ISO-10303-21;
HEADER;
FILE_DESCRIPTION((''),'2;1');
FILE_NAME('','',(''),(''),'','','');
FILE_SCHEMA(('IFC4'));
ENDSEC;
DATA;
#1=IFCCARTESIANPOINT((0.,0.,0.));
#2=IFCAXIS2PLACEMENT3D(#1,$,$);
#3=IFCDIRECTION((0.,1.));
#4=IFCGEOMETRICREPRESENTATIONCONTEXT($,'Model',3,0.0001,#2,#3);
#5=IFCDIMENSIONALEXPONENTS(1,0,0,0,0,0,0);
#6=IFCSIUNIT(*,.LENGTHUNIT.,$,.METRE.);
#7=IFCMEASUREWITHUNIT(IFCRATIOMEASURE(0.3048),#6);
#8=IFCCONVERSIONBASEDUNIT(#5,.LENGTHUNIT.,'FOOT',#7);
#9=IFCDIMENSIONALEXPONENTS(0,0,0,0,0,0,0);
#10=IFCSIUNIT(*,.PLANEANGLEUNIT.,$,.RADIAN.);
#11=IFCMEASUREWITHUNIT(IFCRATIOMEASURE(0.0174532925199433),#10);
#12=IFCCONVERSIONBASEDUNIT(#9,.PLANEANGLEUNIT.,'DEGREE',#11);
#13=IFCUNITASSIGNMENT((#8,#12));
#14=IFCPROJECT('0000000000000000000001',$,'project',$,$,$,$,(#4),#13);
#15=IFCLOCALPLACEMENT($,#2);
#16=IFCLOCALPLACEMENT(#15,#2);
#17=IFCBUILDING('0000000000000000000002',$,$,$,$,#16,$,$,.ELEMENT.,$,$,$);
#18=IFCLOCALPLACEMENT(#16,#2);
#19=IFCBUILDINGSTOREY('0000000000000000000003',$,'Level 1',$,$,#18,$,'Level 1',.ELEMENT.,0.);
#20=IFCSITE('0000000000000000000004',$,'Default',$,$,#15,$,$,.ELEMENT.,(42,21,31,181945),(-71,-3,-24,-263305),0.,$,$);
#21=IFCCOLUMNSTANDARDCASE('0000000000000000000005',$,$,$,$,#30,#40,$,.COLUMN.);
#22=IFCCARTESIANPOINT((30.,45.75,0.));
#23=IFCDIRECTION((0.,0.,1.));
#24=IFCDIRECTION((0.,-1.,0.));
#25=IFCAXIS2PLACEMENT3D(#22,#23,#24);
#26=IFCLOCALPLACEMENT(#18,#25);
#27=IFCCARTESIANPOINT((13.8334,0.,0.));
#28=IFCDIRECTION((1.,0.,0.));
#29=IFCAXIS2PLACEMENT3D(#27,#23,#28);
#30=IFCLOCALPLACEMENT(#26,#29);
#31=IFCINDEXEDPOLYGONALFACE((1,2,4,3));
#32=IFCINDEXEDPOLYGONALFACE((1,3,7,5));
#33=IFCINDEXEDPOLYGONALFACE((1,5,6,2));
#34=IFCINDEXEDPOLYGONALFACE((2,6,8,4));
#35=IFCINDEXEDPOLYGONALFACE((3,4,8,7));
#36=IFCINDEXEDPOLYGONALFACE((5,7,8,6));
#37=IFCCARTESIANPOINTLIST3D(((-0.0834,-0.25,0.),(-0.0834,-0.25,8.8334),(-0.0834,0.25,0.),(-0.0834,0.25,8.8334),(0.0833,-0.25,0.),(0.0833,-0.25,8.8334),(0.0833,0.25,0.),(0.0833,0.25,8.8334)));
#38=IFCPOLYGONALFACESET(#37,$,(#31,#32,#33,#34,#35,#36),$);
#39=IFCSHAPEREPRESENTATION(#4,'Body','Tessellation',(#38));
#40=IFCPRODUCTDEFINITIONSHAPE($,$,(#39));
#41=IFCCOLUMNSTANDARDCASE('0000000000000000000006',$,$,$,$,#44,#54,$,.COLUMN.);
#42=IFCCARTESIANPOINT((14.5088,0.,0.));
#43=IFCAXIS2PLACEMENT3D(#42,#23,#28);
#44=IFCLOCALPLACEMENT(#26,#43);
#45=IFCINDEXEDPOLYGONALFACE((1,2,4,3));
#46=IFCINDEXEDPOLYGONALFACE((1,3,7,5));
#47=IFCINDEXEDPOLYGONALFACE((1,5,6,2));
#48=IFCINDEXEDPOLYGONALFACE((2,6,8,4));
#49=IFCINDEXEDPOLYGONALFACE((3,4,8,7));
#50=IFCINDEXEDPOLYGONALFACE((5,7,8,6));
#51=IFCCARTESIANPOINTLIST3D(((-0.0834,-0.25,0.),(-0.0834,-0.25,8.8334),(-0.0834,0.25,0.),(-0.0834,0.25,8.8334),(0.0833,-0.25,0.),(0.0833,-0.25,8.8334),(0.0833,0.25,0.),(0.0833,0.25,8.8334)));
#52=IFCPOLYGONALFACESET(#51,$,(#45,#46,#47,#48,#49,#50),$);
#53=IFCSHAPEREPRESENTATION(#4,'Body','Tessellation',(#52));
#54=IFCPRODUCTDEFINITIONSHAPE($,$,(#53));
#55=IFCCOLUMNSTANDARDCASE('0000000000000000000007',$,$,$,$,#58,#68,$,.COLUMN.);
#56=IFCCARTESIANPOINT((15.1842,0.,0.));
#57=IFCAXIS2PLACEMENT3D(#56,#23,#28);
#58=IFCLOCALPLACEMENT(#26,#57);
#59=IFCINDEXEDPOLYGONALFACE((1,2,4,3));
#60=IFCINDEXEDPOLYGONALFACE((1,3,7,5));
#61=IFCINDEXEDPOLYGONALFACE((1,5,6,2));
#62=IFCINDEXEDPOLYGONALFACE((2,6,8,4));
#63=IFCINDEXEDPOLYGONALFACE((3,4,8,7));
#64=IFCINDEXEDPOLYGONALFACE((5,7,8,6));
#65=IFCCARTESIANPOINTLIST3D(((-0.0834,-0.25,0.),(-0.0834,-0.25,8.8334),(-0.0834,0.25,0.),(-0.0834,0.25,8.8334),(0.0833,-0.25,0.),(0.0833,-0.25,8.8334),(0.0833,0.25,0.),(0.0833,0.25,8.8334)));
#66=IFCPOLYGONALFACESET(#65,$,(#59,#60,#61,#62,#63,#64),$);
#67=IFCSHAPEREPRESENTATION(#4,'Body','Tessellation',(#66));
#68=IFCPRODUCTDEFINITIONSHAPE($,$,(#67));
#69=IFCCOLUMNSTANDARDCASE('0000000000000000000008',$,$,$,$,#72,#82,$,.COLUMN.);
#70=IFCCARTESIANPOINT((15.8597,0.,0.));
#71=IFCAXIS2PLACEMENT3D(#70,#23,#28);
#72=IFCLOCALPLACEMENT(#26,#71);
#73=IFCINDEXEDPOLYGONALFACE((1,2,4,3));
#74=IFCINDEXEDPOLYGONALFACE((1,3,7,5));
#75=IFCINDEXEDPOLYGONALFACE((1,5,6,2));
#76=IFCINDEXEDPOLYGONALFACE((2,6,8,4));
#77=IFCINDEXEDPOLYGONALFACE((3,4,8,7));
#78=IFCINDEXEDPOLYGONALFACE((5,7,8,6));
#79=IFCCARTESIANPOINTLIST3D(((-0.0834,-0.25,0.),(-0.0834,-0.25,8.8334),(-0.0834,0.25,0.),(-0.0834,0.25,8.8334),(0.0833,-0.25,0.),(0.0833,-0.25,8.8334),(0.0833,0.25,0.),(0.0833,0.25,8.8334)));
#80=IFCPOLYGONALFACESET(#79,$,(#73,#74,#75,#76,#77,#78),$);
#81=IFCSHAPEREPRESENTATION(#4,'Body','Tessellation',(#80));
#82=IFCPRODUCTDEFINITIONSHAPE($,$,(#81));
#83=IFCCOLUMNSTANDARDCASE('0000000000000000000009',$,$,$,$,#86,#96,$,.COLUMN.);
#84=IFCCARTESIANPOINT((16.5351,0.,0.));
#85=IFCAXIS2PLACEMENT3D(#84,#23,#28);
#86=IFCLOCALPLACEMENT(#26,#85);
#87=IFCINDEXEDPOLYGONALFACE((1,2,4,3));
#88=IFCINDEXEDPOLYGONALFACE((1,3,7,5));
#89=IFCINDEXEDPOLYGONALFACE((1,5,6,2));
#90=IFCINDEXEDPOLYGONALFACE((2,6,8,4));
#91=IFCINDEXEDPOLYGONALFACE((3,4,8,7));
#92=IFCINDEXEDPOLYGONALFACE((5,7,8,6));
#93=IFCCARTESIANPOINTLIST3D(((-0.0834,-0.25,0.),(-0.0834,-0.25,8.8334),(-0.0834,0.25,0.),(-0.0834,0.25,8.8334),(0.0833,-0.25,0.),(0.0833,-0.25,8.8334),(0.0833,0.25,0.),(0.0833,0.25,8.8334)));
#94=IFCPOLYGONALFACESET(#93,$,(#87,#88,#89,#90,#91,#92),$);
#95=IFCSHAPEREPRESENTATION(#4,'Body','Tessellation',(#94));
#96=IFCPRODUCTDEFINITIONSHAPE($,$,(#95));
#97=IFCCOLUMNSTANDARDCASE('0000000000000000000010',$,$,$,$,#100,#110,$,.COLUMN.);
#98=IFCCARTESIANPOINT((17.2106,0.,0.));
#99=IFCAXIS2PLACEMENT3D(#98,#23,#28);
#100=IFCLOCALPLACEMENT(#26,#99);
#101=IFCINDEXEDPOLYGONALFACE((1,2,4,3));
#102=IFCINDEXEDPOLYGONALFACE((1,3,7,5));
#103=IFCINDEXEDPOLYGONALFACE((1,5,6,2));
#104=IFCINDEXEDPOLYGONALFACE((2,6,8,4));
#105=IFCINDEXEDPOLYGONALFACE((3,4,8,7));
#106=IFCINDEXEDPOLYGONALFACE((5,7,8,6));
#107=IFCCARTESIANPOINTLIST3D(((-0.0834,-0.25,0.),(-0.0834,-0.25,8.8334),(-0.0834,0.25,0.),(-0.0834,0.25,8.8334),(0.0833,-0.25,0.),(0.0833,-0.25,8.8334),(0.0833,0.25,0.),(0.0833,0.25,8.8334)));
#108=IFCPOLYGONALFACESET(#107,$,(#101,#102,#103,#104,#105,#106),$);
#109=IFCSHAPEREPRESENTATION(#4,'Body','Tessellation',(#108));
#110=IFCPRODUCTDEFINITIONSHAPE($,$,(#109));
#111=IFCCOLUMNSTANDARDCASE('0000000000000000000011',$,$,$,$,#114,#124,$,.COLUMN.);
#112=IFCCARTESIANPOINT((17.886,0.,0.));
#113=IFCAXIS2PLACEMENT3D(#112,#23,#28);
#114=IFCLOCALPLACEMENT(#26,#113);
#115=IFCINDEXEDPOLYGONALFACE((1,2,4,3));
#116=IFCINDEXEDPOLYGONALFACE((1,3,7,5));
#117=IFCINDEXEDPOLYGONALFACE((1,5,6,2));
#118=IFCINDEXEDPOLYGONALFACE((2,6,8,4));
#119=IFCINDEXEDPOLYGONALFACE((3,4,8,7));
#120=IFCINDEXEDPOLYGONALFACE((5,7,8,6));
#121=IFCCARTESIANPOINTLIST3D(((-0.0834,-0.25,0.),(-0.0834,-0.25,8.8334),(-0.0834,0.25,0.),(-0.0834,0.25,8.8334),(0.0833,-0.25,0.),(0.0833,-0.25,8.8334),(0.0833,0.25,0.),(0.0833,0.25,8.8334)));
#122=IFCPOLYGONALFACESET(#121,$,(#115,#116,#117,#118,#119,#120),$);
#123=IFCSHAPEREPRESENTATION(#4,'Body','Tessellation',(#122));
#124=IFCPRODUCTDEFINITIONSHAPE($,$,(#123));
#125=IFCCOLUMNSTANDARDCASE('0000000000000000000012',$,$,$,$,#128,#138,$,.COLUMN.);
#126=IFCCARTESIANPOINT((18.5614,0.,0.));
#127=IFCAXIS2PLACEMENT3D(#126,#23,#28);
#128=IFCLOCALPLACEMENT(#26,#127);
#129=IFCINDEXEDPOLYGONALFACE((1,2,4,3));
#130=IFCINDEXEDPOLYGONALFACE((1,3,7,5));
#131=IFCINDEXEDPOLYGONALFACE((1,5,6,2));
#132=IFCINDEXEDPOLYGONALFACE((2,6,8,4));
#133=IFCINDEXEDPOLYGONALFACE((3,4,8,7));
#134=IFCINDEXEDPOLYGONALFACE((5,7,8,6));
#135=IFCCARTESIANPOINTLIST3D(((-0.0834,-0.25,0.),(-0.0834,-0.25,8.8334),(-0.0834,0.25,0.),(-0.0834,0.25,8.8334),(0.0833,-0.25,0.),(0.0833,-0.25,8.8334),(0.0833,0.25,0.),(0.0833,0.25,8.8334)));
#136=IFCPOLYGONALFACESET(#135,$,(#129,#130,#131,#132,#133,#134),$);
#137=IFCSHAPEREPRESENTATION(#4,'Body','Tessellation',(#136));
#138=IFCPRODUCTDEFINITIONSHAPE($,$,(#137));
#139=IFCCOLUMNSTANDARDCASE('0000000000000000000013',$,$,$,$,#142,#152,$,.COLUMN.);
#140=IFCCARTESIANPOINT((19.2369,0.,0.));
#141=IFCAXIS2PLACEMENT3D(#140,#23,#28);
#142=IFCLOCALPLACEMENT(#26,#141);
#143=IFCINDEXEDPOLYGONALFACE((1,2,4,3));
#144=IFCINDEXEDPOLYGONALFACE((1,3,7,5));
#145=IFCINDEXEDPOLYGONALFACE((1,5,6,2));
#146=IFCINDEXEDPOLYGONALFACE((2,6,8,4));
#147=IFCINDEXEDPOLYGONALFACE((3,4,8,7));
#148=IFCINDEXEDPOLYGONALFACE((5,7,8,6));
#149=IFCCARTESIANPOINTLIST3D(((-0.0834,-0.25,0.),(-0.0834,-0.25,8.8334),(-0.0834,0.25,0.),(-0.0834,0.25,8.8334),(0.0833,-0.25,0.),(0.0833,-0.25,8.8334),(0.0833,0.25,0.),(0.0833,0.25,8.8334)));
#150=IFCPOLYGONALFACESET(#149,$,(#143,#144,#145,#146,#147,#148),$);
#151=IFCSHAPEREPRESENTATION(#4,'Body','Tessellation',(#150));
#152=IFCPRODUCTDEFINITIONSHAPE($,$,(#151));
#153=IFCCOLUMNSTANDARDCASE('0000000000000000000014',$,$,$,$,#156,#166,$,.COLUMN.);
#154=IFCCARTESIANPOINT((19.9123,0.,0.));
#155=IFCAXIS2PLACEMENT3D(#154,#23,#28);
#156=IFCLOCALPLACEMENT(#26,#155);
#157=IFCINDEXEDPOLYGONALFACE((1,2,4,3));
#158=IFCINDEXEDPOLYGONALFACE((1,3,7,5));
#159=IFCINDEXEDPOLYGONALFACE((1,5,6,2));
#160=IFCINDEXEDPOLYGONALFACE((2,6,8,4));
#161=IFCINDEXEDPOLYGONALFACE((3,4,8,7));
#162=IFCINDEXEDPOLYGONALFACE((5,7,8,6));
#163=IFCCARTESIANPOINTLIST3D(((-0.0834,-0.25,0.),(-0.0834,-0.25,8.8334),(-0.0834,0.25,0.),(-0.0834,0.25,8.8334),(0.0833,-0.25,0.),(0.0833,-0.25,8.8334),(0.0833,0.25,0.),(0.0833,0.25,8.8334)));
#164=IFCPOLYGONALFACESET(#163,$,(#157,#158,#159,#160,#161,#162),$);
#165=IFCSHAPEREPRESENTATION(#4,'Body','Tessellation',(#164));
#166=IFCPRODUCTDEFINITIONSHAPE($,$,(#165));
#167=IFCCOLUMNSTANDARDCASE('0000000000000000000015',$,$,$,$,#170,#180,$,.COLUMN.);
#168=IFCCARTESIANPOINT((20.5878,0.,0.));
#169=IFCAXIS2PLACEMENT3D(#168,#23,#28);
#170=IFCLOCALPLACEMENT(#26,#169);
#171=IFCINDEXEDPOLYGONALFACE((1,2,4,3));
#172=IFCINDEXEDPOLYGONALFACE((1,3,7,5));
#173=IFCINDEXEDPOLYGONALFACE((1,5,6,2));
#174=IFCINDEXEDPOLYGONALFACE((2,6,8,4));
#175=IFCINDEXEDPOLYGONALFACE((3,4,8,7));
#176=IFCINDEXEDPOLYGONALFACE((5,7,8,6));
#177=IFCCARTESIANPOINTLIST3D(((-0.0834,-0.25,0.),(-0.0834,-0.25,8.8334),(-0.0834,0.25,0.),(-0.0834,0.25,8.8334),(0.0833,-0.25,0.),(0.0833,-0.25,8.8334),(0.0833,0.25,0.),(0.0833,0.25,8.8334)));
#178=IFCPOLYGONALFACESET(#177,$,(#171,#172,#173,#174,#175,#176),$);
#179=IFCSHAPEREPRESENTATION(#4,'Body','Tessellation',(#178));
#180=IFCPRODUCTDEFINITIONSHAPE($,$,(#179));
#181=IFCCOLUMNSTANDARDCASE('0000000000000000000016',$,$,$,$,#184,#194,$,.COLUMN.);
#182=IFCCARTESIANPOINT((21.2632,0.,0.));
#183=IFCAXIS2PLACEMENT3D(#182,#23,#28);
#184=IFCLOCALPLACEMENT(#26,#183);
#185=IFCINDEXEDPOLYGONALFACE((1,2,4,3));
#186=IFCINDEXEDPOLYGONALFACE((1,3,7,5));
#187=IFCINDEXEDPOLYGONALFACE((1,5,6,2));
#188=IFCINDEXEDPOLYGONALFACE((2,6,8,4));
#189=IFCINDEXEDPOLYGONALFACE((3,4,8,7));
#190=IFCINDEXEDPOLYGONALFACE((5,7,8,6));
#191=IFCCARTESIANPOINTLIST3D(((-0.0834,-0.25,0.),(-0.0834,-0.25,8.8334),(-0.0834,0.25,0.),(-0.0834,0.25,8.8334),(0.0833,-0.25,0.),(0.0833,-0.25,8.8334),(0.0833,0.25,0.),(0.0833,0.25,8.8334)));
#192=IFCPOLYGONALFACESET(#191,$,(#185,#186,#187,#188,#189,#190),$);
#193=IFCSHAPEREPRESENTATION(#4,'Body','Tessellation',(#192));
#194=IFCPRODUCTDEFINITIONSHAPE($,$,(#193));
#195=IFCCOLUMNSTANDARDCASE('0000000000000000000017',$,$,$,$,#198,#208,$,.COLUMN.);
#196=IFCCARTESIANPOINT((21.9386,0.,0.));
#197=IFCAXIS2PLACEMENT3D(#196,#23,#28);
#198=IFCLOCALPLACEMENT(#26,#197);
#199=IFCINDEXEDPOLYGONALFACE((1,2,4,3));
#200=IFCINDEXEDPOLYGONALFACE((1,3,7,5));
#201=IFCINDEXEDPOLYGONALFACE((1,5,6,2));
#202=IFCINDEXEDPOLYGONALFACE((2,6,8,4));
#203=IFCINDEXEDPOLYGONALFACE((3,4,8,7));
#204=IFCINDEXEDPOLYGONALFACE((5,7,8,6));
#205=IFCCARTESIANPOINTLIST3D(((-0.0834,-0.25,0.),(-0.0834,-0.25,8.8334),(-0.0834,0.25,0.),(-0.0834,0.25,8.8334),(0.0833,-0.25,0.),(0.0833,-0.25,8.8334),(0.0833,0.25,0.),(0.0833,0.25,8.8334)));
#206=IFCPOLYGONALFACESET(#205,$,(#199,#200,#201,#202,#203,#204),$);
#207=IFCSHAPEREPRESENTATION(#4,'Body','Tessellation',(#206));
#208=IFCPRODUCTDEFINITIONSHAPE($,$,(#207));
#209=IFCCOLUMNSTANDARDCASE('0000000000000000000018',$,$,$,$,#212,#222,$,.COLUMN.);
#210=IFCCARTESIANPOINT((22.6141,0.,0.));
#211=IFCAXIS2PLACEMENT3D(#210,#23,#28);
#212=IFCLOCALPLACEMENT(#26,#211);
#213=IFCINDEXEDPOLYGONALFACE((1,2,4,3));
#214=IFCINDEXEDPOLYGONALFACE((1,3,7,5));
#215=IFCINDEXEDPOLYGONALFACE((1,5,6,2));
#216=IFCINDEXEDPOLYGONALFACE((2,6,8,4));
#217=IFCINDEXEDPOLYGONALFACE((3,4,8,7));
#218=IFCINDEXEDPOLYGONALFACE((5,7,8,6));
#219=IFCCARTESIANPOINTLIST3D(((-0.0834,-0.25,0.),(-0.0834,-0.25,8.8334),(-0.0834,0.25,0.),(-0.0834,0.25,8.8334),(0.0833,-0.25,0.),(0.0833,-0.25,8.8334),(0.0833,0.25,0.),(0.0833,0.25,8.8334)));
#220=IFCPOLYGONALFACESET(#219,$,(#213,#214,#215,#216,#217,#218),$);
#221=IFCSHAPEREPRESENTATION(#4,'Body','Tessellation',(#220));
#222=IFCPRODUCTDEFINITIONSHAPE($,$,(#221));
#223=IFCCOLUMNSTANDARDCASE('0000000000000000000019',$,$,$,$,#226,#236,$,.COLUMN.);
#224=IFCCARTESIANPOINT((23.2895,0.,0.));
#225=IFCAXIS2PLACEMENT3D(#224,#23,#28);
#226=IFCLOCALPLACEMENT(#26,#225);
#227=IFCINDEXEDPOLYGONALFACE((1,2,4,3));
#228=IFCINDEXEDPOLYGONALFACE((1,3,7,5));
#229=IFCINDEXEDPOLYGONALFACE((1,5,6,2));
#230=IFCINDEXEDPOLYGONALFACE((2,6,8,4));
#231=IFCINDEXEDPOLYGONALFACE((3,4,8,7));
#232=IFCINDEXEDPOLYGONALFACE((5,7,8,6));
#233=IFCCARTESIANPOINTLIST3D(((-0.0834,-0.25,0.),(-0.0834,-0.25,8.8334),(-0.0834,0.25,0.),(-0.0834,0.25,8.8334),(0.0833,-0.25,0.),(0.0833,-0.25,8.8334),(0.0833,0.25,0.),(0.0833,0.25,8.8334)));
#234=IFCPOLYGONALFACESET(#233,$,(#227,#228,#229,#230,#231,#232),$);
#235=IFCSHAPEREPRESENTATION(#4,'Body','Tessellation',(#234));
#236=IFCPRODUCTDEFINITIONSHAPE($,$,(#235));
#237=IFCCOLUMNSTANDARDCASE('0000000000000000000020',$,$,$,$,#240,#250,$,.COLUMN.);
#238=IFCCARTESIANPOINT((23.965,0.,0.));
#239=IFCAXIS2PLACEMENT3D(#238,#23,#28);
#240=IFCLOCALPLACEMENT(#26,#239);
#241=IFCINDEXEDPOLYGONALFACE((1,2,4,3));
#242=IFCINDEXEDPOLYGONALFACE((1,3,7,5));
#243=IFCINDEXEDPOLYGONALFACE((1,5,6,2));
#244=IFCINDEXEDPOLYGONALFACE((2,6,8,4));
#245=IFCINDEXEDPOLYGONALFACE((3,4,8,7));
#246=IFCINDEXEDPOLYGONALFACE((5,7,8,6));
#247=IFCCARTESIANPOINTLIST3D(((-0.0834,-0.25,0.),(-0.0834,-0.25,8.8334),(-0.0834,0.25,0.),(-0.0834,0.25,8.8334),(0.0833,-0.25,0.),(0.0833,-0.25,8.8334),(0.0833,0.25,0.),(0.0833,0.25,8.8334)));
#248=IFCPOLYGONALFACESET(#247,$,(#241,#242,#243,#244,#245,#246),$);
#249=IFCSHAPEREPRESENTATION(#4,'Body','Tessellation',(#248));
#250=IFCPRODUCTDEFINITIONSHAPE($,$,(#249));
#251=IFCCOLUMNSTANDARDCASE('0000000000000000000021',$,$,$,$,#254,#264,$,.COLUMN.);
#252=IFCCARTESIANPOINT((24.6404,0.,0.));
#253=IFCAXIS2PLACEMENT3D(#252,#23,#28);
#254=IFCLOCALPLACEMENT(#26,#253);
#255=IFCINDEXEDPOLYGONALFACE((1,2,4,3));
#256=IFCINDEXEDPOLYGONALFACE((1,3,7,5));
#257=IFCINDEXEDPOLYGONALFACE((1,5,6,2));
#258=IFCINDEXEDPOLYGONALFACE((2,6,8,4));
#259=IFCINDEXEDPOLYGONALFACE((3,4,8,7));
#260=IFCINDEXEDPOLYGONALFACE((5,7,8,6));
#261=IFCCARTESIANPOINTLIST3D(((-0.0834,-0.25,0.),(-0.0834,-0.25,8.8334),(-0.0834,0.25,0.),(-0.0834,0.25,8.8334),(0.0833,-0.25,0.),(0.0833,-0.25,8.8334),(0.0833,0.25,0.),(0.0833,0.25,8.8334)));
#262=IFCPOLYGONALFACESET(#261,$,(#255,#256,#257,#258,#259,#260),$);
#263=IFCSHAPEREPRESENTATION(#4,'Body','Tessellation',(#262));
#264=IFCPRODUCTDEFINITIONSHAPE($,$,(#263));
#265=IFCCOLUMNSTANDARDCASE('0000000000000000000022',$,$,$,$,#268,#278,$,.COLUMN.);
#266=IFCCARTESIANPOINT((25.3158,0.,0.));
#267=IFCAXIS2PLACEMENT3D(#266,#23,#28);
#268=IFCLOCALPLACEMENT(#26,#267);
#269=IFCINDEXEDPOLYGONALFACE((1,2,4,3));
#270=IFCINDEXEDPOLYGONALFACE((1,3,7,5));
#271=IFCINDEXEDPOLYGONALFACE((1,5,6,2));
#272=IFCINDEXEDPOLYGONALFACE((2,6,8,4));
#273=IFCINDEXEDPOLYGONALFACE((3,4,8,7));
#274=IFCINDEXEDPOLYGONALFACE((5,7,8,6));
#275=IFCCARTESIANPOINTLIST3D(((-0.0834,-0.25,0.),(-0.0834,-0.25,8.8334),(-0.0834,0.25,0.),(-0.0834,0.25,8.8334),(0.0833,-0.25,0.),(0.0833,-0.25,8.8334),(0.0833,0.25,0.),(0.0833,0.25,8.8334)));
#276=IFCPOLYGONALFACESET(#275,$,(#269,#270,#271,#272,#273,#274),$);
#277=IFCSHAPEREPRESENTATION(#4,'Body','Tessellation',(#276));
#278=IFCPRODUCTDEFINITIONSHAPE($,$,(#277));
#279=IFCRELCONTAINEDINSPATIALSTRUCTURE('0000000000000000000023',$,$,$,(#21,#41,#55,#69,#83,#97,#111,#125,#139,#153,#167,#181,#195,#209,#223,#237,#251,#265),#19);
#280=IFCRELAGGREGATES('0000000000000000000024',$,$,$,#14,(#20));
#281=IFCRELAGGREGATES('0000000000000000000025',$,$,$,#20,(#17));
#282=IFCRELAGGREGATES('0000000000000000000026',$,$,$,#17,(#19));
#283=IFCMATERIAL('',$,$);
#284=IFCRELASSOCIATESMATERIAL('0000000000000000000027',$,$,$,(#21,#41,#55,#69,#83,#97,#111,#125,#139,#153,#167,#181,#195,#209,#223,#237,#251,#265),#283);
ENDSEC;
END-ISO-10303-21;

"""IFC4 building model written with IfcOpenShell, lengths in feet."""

from ifc_helpers import new_model, entity, si_unit, converted_unit, direction, frame, origin, place, context, project, spatial, rectangle, extrude, material, element, save


model = new_model("IFC4")

# Units and contexts
model_context = context("Model", 3, precision=0.0001, world=origin(), true_north=direction((0.0, 1.0)))
ifc_project = project(units=[converted_unit("LENGTHUNIT", "FOOT", entity("IfcRatioMeasure", 0.3048), si_unit("LENGTHUNIT", "METRE"), dimensions=[1, 0, 0, 0, 0, 0, 0]), converted_unit("PLANEANGLEUNIT", "DEGREE", entity("IfcRatioMeasure", 0.0174532925199433), si_unit("PLANEANGLEUNIT", "RADIAN"), dimensions=[0, 0, 0, 0, 0, 0, 0])], contexts=[model_context])

# Site, building, storey
site_placement = place(None, origin())
site = spatial("IfcSite", under=ifc_project, at=site_placement, Name="Default", CompositionType="ELEMENT", RefLatitude=(42, 21, 31, 181945), RefLongitude=(-71, -3, -24, -263305), RefElevation=0.0)
building_placement = place(site_placement, origin())
building = spatial("IfcBuilding", under=site, at=building_placement, CompositionType="ELEMENT")
storey_placement = place(building_placement, origin())
storey = spatial("IfcBuildingStorey", under=building, at=storey_placement, Name="Level 1", LongName="Level 1", CompositionType="ELEMENT", Elevation=0.0)

# Columns
ifc_material_1 = material(Name="")
placement_1 = place(storey_placement, frame((30.0, 45.75, 0.0), z_axis=(0.0, 0.0, 1.0), x_axis=(0.0, -1.0, 0.0)))
for number, where, z_axis, x_axis in (
    (1, (13.8334, 0.0, 0.0), (0.0, 0.0, 1.0), (1.0, 0.0, 0.0)),
    (2, (14.5088, 0.0, 0.0), (0.0, 0.0, 1.0), (1.0, 0.0, 0.0)),
    (3, (15.1842, 0.0, 0.0), (0.0, 0.0, 1.0), (1.0, 0.0, 0.0)),
    (4, (15.8597, 0.0, 0.0), (0.0, 0.0, 1.0), (1.0, 0.0, 0.0)),
    (5, (16.5351, 0.0, 0.0), (0.0, 0.0, 1.0), (1.0, 0.0, 0.0)),
    (6, (17.2106, 0.0, 0.0), (0.0, 0.0, 1.0), (1.0, 0.0, 0.0)),
    (7, (17.886, 0.0, 0.0), (0.0, 0.0, 1.0), (1.0, 0.0, 0.0)),
    (8, (18.5614, 0.0, 0.0), (0.0, 0.0, 1.0), (1.0, 0.0, 0.0)),
    (9, (19.2369, 0.0, 0.0), (0.0, 0.0, 1.0), (1.0, 0.0, 0.0)),
    (10, (19.9123, 0.0, 0.0), (0.0, 0.0, 1.0), (1.0, 0.0, 0.0)),
    (11, (20.5878, 0.0, 0.0), (0.0, 0.0, 1.0), (1.0, 0.0, 0.0)),
    (12, (21.2632, 0.0, 0.0), (0.0, 0.0, 1.0), (1.0, 0.0, 0.0)),
    (13, (21.9386, 0.0, 0.0), (0.0, 0.0, 1.0), (1.0, 0.0, 0.0)),
    (14, (22.6141, 0.0, 0.0), (0.0, 0.0, 1.0), (1.0, 0.0, 0.0)),
    (15, (23.2895, 0.0, 0.0), (0.0, 0.0, 1.0), (1.0, 0.0, 0.0)),
    (16, (23.965, 0.0, 0.0), (0.0, 0.0, 1.0), (1.0, 0.0, 0.0)),
    (17, (24.6404, 0.0, 0.0), (0.0, 0.0, 1.0), (1.0, 0.0, 0.0)),
    (18, (25.3158, 0.0, 0.0), (0.0, 0.0, 1.0), (1.0, 0.0, 0.0)),
):
    element("IfcColumnStandardCase", number, at=place(placement_1, frame(where, z_axis=z_axis, x_axis=x_axis)), inside=storey, material=ifc_material_1, PredefinedType="COLUMN", context=model_context, shape_type="SweptSolid", body=[
        extrude(rectangle(XDim=0.1667, YDim=0.5), origin(), (0.0, 0.0, 1.0), 8.8334),
    ])

save(model, "model.ifc")
